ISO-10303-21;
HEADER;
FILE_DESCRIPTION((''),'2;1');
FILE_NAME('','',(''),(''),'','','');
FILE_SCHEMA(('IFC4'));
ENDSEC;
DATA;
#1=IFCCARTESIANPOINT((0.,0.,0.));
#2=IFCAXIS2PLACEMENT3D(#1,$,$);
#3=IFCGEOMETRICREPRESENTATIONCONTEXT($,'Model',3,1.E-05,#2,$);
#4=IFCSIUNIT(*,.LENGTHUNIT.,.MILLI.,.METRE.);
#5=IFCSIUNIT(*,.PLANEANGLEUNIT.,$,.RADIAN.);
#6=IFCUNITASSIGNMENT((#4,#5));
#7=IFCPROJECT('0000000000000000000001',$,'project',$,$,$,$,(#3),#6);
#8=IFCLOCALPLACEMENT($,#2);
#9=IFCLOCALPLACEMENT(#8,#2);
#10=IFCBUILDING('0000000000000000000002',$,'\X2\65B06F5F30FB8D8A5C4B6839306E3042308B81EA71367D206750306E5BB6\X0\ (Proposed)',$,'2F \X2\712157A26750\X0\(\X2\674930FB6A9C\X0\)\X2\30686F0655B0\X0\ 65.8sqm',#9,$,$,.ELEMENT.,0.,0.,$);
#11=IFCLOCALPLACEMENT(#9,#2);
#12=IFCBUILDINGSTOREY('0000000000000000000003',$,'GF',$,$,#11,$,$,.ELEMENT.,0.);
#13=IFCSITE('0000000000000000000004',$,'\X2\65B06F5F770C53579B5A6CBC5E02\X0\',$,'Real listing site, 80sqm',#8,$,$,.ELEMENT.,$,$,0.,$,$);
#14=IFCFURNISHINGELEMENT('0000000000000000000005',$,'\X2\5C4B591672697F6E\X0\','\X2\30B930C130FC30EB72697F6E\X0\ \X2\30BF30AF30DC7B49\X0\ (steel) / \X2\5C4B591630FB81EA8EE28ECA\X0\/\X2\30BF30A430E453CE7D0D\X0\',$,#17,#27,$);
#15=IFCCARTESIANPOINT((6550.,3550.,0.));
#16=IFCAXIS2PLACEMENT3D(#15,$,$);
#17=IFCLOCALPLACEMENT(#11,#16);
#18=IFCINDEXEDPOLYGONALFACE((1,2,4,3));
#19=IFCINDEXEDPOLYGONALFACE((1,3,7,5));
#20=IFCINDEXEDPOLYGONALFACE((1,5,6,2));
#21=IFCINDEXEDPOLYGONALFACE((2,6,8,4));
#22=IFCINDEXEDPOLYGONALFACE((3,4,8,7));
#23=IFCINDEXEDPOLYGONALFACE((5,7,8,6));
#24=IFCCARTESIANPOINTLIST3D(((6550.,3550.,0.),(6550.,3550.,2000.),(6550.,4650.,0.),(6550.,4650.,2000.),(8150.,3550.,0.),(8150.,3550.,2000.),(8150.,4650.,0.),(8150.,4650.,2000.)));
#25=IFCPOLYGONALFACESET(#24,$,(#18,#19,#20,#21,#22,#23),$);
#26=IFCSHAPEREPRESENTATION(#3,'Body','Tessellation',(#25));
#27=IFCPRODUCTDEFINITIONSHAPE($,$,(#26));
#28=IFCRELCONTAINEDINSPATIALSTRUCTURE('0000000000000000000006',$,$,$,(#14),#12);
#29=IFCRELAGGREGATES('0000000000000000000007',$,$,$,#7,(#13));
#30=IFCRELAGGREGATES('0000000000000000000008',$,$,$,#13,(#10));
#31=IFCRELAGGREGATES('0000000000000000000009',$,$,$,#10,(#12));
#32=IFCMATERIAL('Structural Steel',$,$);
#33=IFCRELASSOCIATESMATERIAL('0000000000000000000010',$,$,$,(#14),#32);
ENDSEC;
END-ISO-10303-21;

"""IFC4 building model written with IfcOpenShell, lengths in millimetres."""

from ifc_helpers import new_model, si_unit, frame, frame_2d, origin, place, context, project, spatial, rectangle, extrude, material, element, save


model = new_model("IFC4")

# Units and contexts
model_context = context("Model", 3, precision=1e-05, world=origin())
ifc_project = project(units=[si_unit("LENGTHUNIT", "METRE", prefix="MILLI"), si_unit("PLANEANGLEUNIT", "RADIAN")], contexts=[model_context])

# Site, building, storey
site_placement = place(None, origin())
site = spatial("IfcSite", under=ifc_project, at=site_placement, Name="新潟県南魚沼市", ObjectType="Real listing site, 80sqm", CompositionType="ELEMENT", RefElevation=0.0)
building_placement = place(site_placement, origin())
building = spatial("IfcBuilding", under=site, at=building_placement, Name="新潟・越屋根のある自然素材の家 (Proposed)", ObjectType="2F 無垢材(杉・檜)と漆喰 65.8sqm", CompositionType="ELEMENT", ElevationOfRefHeight=0.0, ElevationOfTerrain=0.0)
storey_placement = place(building_placement, origin())
storey = spatial("IfcBuildingStorey", under=building, at=storey_placement, Name="GF", CompositionType="ELEMENT", Elevation=0.0)

# Shared definitions
ifc_material_1 = material(Name="Structural Steel")

# Furnishing element
furnishing_1_placement = place(storey_placement, frame((6550.0, 3550.0, 0.0)))
element("IfcFurnishingElement", 1, at=furnishing_1_placement, inside=storey, material=ifc_material_1, Name="屋外物置", Description="スチール物置 タクボ等 (steel) / 屋外・自転車/タイヤ収納", context=model_context, shape_type="SweptSolid", body=[
    extrude(rectangle(XDim=1600.0, YDim=1100.0, at=frame_2d((800.0, 550.0))), frame((6550.0, 3550.0, 0.0)), (0.0, 0.0, 1.0), 2000.0),
])

save(model, "model.ifc")
